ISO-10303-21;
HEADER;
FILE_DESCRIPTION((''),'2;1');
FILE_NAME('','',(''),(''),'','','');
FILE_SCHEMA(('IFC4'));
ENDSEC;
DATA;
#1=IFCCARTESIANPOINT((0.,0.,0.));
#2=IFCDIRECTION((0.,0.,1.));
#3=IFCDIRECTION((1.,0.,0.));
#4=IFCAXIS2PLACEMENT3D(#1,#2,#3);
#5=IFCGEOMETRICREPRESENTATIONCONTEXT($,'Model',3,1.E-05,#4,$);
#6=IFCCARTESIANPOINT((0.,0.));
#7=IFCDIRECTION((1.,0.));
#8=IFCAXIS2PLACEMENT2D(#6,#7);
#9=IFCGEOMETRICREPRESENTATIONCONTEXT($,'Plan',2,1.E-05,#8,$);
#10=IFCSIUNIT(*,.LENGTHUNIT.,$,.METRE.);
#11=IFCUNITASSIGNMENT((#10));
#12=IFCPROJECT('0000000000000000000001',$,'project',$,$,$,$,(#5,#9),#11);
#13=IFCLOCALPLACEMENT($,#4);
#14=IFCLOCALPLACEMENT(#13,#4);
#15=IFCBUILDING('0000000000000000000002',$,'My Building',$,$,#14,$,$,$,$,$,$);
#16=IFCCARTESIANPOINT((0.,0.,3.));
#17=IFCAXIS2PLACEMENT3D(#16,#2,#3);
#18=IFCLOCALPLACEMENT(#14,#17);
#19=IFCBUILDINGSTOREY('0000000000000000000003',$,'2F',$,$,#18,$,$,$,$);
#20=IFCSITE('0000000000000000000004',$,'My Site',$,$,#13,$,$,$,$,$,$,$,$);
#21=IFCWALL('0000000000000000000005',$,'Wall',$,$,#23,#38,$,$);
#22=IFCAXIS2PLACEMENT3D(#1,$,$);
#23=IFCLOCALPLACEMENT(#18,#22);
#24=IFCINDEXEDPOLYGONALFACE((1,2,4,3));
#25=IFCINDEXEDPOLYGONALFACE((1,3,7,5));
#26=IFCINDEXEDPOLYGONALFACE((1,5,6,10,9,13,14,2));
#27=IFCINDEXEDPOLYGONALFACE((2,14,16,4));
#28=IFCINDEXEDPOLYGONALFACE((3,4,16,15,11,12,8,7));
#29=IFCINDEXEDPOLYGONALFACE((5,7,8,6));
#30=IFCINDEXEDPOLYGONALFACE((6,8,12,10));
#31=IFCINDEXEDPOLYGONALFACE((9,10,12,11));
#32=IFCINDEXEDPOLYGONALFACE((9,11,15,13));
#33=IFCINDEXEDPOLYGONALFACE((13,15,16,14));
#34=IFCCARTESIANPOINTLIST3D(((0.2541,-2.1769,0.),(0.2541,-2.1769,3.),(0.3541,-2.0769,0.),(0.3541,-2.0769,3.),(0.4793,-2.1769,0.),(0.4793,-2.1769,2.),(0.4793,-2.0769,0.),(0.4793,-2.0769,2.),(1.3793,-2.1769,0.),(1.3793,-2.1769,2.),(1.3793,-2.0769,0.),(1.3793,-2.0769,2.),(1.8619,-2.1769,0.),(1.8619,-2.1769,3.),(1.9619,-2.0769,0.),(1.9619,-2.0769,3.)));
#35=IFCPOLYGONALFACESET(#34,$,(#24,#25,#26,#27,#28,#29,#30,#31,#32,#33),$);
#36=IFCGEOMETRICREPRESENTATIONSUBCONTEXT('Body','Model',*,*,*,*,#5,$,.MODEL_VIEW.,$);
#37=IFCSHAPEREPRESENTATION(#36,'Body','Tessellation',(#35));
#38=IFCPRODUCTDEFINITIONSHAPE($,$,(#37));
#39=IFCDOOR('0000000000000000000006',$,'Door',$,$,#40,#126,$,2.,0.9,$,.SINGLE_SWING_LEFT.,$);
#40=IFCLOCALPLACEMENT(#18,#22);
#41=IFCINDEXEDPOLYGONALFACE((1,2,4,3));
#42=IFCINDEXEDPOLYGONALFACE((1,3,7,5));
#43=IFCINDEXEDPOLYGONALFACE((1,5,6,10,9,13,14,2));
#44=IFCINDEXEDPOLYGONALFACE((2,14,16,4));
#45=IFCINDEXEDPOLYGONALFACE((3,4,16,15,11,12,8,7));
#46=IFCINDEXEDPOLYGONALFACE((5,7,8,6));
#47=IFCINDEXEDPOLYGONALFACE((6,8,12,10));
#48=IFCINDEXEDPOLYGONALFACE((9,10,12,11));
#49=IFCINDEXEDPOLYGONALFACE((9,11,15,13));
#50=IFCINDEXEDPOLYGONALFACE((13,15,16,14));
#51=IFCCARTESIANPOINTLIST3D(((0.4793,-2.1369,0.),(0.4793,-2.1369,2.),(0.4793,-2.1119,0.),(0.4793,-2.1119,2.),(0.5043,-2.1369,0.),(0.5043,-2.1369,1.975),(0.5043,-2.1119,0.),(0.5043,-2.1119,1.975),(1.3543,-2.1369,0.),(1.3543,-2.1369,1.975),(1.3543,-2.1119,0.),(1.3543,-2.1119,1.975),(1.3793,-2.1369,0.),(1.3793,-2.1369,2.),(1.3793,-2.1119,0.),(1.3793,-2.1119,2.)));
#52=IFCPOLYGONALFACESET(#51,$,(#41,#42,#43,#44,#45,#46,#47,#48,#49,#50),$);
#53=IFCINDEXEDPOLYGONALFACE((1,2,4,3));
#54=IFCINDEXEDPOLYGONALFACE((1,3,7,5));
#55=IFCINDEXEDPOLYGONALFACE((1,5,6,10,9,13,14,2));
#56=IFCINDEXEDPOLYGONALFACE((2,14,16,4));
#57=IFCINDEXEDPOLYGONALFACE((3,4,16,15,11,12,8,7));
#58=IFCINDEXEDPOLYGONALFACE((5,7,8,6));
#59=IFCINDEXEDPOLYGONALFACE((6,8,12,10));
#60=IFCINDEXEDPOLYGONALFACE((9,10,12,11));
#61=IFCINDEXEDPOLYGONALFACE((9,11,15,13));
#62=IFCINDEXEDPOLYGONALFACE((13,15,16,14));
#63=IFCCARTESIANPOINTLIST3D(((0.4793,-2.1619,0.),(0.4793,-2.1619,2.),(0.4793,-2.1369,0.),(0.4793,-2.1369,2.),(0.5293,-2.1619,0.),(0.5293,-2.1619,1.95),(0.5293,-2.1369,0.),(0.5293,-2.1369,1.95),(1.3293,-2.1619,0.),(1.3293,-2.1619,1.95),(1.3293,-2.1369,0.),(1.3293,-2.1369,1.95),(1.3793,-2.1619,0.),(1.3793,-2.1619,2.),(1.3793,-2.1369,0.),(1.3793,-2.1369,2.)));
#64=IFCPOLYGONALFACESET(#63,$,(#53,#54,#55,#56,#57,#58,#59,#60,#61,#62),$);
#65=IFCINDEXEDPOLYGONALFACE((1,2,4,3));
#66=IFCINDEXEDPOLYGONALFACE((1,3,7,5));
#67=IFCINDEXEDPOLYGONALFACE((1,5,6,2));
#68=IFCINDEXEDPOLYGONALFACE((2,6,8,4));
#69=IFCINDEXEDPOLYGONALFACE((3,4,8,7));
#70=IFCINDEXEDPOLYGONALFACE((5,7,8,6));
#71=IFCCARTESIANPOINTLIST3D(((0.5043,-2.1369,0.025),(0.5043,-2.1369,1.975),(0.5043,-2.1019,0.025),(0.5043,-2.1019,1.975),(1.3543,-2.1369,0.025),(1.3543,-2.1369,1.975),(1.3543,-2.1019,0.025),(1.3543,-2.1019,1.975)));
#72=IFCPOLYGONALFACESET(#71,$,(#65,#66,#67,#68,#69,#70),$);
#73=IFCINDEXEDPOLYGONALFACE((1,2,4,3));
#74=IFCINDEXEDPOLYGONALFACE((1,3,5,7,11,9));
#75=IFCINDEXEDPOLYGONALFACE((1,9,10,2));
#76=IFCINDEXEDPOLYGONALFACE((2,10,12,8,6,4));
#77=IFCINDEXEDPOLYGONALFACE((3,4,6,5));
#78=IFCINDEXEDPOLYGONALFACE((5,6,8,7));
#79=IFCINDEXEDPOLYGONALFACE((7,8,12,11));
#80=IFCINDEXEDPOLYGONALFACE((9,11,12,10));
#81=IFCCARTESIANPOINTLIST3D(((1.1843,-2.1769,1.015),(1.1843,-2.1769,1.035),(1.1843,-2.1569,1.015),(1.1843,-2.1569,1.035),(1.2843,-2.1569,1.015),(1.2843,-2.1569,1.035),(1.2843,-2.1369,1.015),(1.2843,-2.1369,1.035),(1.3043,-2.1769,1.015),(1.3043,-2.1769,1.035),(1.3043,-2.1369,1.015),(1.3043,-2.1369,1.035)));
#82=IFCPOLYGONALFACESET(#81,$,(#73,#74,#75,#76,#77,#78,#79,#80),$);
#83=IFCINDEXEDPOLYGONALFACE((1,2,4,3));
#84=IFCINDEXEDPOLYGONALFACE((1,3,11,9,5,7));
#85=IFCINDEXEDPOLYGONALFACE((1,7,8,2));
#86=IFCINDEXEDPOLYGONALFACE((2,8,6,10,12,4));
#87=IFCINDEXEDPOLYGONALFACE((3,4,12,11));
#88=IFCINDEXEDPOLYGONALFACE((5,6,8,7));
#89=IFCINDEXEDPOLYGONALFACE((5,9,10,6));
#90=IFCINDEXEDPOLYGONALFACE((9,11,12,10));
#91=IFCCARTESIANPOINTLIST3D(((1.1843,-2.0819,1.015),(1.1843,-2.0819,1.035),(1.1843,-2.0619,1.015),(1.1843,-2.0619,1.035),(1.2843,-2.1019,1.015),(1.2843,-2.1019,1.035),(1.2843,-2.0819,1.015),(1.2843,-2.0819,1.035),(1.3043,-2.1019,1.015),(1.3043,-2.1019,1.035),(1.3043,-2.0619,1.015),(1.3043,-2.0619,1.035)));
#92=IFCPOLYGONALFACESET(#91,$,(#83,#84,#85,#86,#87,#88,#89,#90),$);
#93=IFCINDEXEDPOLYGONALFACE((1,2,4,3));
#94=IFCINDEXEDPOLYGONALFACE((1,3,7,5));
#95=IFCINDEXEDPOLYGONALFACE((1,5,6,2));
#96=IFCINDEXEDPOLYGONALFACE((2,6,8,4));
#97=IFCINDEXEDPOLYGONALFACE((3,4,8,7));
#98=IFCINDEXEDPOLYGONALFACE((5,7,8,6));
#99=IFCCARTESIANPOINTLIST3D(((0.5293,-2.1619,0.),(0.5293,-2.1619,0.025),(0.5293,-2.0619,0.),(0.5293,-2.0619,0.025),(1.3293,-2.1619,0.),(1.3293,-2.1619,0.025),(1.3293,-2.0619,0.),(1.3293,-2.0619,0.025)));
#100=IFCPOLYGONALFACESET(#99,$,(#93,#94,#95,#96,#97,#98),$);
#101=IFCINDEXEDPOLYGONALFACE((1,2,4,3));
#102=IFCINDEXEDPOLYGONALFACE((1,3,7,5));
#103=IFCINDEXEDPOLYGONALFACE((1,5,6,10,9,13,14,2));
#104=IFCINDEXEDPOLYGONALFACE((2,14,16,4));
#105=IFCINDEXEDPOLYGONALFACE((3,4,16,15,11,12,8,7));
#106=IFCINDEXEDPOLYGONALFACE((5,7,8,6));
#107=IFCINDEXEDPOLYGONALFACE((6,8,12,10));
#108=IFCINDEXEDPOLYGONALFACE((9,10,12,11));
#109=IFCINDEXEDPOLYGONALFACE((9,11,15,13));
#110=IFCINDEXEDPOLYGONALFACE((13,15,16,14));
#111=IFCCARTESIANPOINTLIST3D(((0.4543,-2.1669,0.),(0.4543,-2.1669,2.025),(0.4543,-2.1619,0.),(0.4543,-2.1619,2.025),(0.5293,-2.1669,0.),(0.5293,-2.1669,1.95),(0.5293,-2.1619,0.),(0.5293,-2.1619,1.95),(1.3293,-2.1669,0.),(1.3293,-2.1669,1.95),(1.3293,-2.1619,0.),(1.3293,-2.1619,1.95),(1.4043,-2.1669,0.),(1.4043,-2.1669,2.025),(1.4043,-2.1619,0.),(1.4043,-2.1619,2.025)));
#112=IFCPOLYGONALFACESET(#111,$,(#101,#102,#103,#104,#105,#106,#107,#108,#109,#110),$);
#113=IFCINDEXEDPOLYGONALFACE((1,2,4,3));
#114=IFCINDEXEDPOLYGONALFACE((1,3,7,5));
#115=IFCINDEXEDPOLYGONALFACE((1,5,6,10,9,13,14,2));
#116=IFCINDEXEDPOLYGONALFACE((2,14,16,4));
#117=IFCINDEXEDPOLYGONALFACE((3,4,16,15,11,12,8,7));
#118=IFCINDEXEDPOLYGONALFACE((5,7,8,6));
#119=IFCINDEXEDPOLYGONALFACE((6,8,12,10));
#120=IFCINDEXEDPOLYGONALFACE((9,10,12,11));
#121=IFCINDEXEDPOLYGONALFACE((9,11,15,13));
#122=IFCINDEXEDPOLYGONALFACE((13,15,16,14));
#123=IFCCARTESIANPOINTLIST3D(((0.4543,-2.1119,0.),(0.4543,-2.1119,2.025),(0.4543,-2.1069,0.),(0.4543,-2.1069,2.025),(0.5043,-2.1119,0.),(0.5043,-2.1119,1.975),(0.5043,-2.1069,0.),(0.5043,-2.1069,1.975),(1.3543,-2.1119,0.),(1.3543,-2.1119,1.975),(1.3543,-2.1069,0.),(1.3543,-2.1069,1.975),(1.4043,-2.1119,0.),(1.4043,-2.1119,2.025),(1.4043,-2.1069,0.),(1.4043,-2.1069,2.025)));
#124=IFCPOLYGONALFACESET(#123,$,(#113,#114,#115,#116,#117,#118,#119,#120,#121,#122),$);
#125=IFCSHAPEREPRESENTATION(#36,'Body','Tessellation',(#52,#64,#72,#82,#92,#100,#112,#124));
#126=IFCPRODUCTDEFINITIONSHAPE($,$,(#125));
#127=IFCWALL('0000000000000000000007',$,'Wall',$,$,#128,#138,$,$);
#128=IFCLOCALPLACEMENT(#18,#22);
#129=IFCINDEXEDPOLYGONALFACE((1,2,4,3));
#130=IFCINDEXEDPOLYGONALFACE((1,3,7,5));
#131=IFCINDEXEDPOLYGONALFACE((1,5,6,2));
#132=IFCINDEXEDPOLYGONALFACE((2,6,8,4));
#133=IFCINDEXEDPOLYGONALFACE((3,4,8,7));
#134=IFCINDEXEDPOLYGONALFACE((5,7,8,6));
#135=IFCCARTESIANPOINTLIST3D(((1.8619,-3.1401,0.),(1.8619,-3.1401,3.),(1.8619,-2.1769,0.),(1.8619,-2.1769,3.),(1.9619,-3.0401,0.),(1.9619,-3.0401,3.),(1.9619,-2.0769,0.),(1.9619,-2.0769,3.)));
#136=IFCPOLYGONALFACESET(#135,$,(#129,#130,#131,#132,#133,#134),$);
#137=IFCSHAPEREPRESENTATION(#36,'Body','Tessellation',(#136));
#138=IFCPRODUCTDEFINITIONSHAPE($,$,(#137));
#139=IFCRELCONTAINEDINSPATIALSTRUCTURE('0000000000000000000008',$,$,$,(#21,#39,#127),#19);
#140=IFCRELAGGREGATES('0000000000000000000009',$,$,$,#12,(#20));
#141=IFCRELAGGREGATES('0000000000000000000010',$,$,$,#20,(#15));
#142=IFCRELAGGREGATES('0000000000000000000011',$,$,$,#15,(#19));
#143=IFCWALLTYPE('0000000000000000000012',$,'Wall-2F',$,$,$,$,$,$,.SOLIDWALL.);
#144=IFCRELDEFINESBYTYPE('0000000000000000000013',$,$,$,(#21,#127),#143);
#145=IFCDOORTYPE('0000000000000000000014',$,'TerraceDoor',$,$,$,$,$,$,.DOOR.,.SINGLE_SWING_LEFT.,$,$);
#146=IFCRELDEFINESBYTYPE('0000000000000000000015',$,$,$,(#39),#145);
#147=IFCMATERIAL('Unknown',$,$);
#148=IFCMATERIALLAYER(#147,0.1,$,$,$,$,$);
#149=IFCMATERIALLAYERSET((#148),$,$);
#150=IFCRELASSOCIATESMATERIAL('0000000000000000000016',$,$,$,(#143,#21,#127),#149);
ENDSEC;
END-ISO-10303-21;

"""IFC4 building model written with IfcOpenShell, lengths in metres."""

from ifc_helpers import new_model, entity, si_unit, frame, origin_with_axes, origin_2d_with_axis, place, context, subcontext, project, spatial, line, indexed_curve, outline, extrude, shape, source, transform, mapped, material, layer, layer_set, layer_usage, type_object, type_shapes, element, fill, save


model = new_model("IFC4")

# Units and contexts
model_context = context("Model", 3, precision=1e-05, world=origin_with_axes())
plan_context = context("Plan", 2, precision=1e-05, world=origin_2d_with_axis())
body_context_1 = subcontext(model_context, "Body", "Model", "MODEL_VIEW")
body_context_2 = subcontext(plan_context, "Body", "Plan", "PLAN_VIEW")
ifc_project = project(units=[si_unit("LENGTHUNIT", "METRE")], contexts=[model_context, plan_context])

# Site, building, storey
site_placement = place(None, origin_with_axes())
site = spatial("IfcSite", under=ifc_project, at=site_placement, Name="My Site")
building_placement = place(site_placement, origin_with_axes())
building = spatial("IfcBuilding", under=site, at=building_placement, Name="My Building")
storey_placement = place(building_placement, frame((0.0, 0.0, 3.0), z_axis=(0.0, 0.0, 1.0), x_axis=(1.0, 0.0, 0.0)))
storey = spatial("IfcBuildingStorey", under=building, at=storey_placement, Name="2F")

# Shared definitions
ifc_material = material(Name="Unknown")

# Shared definitions
ifc_layer_1 = layer(ifc_material, 0.1)
ifc_layer_set_1 = layer_set([ifc_layer_1])
wall_type_1 = type_object("IfcWallType", Name="Wall-2F", PredefinedType="SOLIDWALL", material=ifc_layer_set_1)

# Wall, opening, door
ifc_layer_usage_1 = layer_usage(ifc_layer_set_1, "AXIS2", "POSITIVE", 0.0)
wall_1_placement = place(storey_placement, frame((0.2541, -2.1769, 0.0), z_axis=(0.0, 0.0, 1.0), x_axis=(1.0, 0.0, 0.0)))
wall_1 = element("IfcWall", 1, at=wall_1_placement, inside=storey, type_object=wall_type_1, material=ifc_layer_usage_1, Name="Wall", context=body_context_1, shape_type="SweptSolid", body=[
    extrude(outline(indexed_curve([(0.0, 0.0), (0.1, 0.1), (1.7078, 0.1), (1.6078, 0.0)], segments=[line(1, 2, 3, 4, 1)])), origin_with_axes(), (0.0, 0.0, 1.0), 3.0),
])
shared_shape_1 = source(origin_with_axes(), body_context_1, "Body", "SweptSolid", [
    extrude(outline(indexed_curve([(0.0, 0.0), (0.9, 0.0), (0.9, 2.0), (0.0, 2.0)], segments=[line(1, 2, 3, 4, 1)])), frame((0.0, -0.6, 0.0), z_axis=(0.0, -1.0, 0.0), x_axis=(1.0, 0.0, 0.0)), (0.0, 0.0, -1.0), 1.2),
])
opening_1_placement = place(wall_1_placement, frame((0.2252, 0.015, 0.0), z_axis=(0.0, 0.0, 1.0), x_axis=(1.0, -0.000001, 0.0)))
opening_1 = element("IfcOpeningElement", 2, at=opening_1_placement, cuts=wall_1, PredefinedType="OPENING", context=body_context_1, shape_type="MappedRepresentation", body=[
    mapped(shared_shape_1, transform((0.0, 0.0, 0.0), x_axis=(1.0, 0.0, 0.0), y_axis=(0.0, 1.0, 0.0), z_axis=(0.0, 0.0, 1.0), scale=1.0)),
])
door_type_1 = type_object("IfcDoorType", Name="TerraceDoor", OperationType="SINGLE_SWING_LEFT", PredefinedType="DOOR")
shared_shape_2 = source(origin_with_axes(), body_context_1, "Body", "SweptSolid", [
    extrude(outline(indexed_curve([(0.0, 0.0), (0.0, 2.0), (0.9, 2.0), (0.9, 0.0), (0.875, 0.0), (0.875, 1.975), (0.025, 1.975), (0.025, 0.0)], segments=[line(1, 2, 3, 4, 5, 6, 7, 8, 1)])), frame((0.0, 0.025, 0.0), z_axis=(0.0, -1.0, 0.0), x_axis=(1.0, 0.0, 0.0)), (0.0, 0.0, -1.0), 0.025),
    extrude(outline(indexed_curve([(0.0, 0.0), (0.0, 2.0), (0.9, 2.0), (0.9, 0.0), (0.85, 0.0), (0.85, 1.95), (0.05, 1.95), (0.05, 0.0)], segments=[line(1, 2, 3, 4, 5, 6, 7, 8, 1)])), frame((0.0, 0.0, 0.0), z_axis=(0.0, -1.0, 0.0), x_axis=(1.0, 0.0, 0.0)), (0.0, 0.0, -1.0), 0.025),
    extrude(outline(indexed_curve([(0.0, 0.0), (0.85, 0.0), (0.85, 0.035), (0.0, 0.035)], segments=[line(1, 2, 3, 4, 1)])), frame((0.025, 0.025, 0.025), z_axis=(0.0, 0.0, 1.0), x_axis=(1.0, 0.0, 0.0)), (0.0, 0.0, 1.0), 1.95),
    extrude(outline(indexed_curve([(0.0, 0.0), (0.0, -0.04), (-0.12, -0.04), (-0.12, -0.02), (-0.02, -0.02), (-0.02, 0.0)], segments=[line(1, 2, 3, 4, 5, 6, 1)])), frame((0.825, 0.025, 1.015), z_axis=(0.0, 0.0, 1.0), x_axis=(1.0, 0.0, 0.0)), (0.0, 0.0, 1.0), 0.02),
    extrude(outline(indexed_curve([(0.0, 0.0), (0.0, 0.04), (-0.12, 0.04), (-0.12, 0.02), (-0.02, 0.02), (-0.02, 0.0)], segments=[line(1, 2, 3, 4, 5, 6, 1)])), frame((0.825, 0.06, 1.015), z_axis=(0.0, 0.0, 1.0), x_axis=(1.0, 0.0, 0.0)), (0.0, 0.0, 1.0), 0.02),
    extrude(outline(indexed_curve([(0.0, 0.0), (0.8, 0.0), (0.8, 0.1), (0.0, 0.1)], segments=[line(1, 2, 3, 4, 1)])), frame((0.05, 0.0, 0.0), z_axis=(0.0, 0.0, 1.0), x_axis=(1.0, 0.0, 0.0)), (0.0, 0.0, 1.0), 0.025),
    extrude(outline(indexed_curve([(0.0, 0.0), (0.0, 2.025), (0.95, 2.025), (0.95, 0.0), (0.875, 0.0), (0.875, 1.95), (0.075, 1.95), (0.075, 0.0)], segments=[line(1, 2, 3, 4, 5, 6, 7, 8, 1)])), frame((-0.025, -0.005, 0.0), z_axis=(0.0, -1.0, 0.0), x_axis=(1.0, 0.0, 0.0)), (0.0, 0.0, -1.0), 0.005),
    extrude(outline(indexed_curve([(0.0, 0.0), (0.0, 2.025), (0.95, 2.025), (0.95, 0.0), (0.9, 0.0), (0.9, 1.975), (0.05, 1.975), (0.05, 0.0)], segments=[line(1, 2, 3, 4, 5, 6, 7, 8, 1)])), frame((-0.025, 0.05, 0.0), z_axis=(0.0, -1.0, 0.0), x_axis=(1.0, 0.0, 0.0)), (0.0, 0.0, -1.0), 0.005),
])
shared_shape_3 = source(origin_with_axes(), body_context_2, "Body", "Curve2D", [
    entity("IfcIndexedPolyCurve", entity("IfcCartesianPointList2D", [[0.0, 0.0], [0.0, 0.05], [0.025, 0.05], [0.025, 0.025], [0.05, 0.025], [0.05, 0.0]]), [entity("IfcLineIndex", [1, 2, 3, 4, 5, 6, 1])]),
    entity("IfcIndexedPolyCurve", entity("IfcCartesianPointList2D", [[0.9, 0.0], [0.9, 0.05], [0.875, 0.05], [0.875, 0.025], [0.85, 0.025], [0.85, 0.0]]), [entity("IfcLineIndex", [1, 2, 3, 4, 5, 6, 1])]),
    entity("IfcTrimmedCurve", entity("IfcEllipse", entity("IfcAxis2Placement2D", entity("IfcCartesianPoint", [0.06, 0.05]), entity("IfcDirection", [1.0, 0.0])), 0.815, 0.85), [entity("IfcCartesianPoint", [0.875, 0.05])], [entity("IfcCartesianPoint", [0.06, 0.9])], True, "CARTESIAN"),
    entity("IfcIndexedPolyCurve", entity("IfcCartesianPointList2D", [[0.025, 0.05], [0.06, 0.05], [0.06, 0.9], [0.025, 0.9]]), [entity("IfcLineIndex", [1, 2, 3, 4, 1])]),
])
type_shapes(door_type_1, [shared_shape_2, shared_shape_3])
door_1_placement = place(opening_1_placement, frame((0.0, 0.0, 0.0), z_axis=(0.0, 0.0, 1.0), x_axis=(1.0, 0.0, 0.0)))
door_1 = element("IfcDoor", 3, at=door_1_placement, inside=storey, type_object=door_type_1, Name="Door", OperationType="SINGLE_SWING_LEFT", OverallHeight=2.0, OverallWidth=0.9, shapes=[
    shape(body_context_1, "Body", "MappedRepresentation", [mapped(shared_shape_2, transform((0.0, 0.0, 0.0), x_axis=(1.0, 0.0, 0.0), y_axis=(0.0, 1.0, 0.0), z_axis=(0.0, 0.0, 1.0), scale=1.0))]),
    shape(body_context_2, "Body", "MappedRepresentation", [mapped(shared_shape_3, transform((0.0, 0.0, 0.0), x_axis=(1.0, 0.0, 0.0), y_axis=(0.0, 1.0, 0.0), z_axis=(0.0, 0.0, 1.0), scale=1.0))]),
])
fill(opening_1, door_1)

# Wall
ifc_layer_usage_2 = layer_usage(ifc_layer_set_1, "AXIS2", "POSITIVE", 0.0)
wall_2_placement = place(storey_placement, frame((1.8619, -2.1769, 0.0), z_axis=(0.0, 0.0, 1.0), x_axis=(0.0, -1.0, 0.0)))
element("IfcWall", 4, at=wall_2_placement, inside=storey, type_object=wall_type_1, material=ifc_layer_usage_2, Name="Wall", context=body_context_1, shape_type="SweptSolid", body=[
    extrude(outline(indexed_curve([(0.0, 0.0), (-0.1, 0.1), (0.8632, 0.1), (0.9632, 0.0)], segments=[line(1, 2, 3, 4, 1)])), origin_with_axes(), (0.0, 0.0, 1.0), 3.0),
])

save(model, "model.ifc")
